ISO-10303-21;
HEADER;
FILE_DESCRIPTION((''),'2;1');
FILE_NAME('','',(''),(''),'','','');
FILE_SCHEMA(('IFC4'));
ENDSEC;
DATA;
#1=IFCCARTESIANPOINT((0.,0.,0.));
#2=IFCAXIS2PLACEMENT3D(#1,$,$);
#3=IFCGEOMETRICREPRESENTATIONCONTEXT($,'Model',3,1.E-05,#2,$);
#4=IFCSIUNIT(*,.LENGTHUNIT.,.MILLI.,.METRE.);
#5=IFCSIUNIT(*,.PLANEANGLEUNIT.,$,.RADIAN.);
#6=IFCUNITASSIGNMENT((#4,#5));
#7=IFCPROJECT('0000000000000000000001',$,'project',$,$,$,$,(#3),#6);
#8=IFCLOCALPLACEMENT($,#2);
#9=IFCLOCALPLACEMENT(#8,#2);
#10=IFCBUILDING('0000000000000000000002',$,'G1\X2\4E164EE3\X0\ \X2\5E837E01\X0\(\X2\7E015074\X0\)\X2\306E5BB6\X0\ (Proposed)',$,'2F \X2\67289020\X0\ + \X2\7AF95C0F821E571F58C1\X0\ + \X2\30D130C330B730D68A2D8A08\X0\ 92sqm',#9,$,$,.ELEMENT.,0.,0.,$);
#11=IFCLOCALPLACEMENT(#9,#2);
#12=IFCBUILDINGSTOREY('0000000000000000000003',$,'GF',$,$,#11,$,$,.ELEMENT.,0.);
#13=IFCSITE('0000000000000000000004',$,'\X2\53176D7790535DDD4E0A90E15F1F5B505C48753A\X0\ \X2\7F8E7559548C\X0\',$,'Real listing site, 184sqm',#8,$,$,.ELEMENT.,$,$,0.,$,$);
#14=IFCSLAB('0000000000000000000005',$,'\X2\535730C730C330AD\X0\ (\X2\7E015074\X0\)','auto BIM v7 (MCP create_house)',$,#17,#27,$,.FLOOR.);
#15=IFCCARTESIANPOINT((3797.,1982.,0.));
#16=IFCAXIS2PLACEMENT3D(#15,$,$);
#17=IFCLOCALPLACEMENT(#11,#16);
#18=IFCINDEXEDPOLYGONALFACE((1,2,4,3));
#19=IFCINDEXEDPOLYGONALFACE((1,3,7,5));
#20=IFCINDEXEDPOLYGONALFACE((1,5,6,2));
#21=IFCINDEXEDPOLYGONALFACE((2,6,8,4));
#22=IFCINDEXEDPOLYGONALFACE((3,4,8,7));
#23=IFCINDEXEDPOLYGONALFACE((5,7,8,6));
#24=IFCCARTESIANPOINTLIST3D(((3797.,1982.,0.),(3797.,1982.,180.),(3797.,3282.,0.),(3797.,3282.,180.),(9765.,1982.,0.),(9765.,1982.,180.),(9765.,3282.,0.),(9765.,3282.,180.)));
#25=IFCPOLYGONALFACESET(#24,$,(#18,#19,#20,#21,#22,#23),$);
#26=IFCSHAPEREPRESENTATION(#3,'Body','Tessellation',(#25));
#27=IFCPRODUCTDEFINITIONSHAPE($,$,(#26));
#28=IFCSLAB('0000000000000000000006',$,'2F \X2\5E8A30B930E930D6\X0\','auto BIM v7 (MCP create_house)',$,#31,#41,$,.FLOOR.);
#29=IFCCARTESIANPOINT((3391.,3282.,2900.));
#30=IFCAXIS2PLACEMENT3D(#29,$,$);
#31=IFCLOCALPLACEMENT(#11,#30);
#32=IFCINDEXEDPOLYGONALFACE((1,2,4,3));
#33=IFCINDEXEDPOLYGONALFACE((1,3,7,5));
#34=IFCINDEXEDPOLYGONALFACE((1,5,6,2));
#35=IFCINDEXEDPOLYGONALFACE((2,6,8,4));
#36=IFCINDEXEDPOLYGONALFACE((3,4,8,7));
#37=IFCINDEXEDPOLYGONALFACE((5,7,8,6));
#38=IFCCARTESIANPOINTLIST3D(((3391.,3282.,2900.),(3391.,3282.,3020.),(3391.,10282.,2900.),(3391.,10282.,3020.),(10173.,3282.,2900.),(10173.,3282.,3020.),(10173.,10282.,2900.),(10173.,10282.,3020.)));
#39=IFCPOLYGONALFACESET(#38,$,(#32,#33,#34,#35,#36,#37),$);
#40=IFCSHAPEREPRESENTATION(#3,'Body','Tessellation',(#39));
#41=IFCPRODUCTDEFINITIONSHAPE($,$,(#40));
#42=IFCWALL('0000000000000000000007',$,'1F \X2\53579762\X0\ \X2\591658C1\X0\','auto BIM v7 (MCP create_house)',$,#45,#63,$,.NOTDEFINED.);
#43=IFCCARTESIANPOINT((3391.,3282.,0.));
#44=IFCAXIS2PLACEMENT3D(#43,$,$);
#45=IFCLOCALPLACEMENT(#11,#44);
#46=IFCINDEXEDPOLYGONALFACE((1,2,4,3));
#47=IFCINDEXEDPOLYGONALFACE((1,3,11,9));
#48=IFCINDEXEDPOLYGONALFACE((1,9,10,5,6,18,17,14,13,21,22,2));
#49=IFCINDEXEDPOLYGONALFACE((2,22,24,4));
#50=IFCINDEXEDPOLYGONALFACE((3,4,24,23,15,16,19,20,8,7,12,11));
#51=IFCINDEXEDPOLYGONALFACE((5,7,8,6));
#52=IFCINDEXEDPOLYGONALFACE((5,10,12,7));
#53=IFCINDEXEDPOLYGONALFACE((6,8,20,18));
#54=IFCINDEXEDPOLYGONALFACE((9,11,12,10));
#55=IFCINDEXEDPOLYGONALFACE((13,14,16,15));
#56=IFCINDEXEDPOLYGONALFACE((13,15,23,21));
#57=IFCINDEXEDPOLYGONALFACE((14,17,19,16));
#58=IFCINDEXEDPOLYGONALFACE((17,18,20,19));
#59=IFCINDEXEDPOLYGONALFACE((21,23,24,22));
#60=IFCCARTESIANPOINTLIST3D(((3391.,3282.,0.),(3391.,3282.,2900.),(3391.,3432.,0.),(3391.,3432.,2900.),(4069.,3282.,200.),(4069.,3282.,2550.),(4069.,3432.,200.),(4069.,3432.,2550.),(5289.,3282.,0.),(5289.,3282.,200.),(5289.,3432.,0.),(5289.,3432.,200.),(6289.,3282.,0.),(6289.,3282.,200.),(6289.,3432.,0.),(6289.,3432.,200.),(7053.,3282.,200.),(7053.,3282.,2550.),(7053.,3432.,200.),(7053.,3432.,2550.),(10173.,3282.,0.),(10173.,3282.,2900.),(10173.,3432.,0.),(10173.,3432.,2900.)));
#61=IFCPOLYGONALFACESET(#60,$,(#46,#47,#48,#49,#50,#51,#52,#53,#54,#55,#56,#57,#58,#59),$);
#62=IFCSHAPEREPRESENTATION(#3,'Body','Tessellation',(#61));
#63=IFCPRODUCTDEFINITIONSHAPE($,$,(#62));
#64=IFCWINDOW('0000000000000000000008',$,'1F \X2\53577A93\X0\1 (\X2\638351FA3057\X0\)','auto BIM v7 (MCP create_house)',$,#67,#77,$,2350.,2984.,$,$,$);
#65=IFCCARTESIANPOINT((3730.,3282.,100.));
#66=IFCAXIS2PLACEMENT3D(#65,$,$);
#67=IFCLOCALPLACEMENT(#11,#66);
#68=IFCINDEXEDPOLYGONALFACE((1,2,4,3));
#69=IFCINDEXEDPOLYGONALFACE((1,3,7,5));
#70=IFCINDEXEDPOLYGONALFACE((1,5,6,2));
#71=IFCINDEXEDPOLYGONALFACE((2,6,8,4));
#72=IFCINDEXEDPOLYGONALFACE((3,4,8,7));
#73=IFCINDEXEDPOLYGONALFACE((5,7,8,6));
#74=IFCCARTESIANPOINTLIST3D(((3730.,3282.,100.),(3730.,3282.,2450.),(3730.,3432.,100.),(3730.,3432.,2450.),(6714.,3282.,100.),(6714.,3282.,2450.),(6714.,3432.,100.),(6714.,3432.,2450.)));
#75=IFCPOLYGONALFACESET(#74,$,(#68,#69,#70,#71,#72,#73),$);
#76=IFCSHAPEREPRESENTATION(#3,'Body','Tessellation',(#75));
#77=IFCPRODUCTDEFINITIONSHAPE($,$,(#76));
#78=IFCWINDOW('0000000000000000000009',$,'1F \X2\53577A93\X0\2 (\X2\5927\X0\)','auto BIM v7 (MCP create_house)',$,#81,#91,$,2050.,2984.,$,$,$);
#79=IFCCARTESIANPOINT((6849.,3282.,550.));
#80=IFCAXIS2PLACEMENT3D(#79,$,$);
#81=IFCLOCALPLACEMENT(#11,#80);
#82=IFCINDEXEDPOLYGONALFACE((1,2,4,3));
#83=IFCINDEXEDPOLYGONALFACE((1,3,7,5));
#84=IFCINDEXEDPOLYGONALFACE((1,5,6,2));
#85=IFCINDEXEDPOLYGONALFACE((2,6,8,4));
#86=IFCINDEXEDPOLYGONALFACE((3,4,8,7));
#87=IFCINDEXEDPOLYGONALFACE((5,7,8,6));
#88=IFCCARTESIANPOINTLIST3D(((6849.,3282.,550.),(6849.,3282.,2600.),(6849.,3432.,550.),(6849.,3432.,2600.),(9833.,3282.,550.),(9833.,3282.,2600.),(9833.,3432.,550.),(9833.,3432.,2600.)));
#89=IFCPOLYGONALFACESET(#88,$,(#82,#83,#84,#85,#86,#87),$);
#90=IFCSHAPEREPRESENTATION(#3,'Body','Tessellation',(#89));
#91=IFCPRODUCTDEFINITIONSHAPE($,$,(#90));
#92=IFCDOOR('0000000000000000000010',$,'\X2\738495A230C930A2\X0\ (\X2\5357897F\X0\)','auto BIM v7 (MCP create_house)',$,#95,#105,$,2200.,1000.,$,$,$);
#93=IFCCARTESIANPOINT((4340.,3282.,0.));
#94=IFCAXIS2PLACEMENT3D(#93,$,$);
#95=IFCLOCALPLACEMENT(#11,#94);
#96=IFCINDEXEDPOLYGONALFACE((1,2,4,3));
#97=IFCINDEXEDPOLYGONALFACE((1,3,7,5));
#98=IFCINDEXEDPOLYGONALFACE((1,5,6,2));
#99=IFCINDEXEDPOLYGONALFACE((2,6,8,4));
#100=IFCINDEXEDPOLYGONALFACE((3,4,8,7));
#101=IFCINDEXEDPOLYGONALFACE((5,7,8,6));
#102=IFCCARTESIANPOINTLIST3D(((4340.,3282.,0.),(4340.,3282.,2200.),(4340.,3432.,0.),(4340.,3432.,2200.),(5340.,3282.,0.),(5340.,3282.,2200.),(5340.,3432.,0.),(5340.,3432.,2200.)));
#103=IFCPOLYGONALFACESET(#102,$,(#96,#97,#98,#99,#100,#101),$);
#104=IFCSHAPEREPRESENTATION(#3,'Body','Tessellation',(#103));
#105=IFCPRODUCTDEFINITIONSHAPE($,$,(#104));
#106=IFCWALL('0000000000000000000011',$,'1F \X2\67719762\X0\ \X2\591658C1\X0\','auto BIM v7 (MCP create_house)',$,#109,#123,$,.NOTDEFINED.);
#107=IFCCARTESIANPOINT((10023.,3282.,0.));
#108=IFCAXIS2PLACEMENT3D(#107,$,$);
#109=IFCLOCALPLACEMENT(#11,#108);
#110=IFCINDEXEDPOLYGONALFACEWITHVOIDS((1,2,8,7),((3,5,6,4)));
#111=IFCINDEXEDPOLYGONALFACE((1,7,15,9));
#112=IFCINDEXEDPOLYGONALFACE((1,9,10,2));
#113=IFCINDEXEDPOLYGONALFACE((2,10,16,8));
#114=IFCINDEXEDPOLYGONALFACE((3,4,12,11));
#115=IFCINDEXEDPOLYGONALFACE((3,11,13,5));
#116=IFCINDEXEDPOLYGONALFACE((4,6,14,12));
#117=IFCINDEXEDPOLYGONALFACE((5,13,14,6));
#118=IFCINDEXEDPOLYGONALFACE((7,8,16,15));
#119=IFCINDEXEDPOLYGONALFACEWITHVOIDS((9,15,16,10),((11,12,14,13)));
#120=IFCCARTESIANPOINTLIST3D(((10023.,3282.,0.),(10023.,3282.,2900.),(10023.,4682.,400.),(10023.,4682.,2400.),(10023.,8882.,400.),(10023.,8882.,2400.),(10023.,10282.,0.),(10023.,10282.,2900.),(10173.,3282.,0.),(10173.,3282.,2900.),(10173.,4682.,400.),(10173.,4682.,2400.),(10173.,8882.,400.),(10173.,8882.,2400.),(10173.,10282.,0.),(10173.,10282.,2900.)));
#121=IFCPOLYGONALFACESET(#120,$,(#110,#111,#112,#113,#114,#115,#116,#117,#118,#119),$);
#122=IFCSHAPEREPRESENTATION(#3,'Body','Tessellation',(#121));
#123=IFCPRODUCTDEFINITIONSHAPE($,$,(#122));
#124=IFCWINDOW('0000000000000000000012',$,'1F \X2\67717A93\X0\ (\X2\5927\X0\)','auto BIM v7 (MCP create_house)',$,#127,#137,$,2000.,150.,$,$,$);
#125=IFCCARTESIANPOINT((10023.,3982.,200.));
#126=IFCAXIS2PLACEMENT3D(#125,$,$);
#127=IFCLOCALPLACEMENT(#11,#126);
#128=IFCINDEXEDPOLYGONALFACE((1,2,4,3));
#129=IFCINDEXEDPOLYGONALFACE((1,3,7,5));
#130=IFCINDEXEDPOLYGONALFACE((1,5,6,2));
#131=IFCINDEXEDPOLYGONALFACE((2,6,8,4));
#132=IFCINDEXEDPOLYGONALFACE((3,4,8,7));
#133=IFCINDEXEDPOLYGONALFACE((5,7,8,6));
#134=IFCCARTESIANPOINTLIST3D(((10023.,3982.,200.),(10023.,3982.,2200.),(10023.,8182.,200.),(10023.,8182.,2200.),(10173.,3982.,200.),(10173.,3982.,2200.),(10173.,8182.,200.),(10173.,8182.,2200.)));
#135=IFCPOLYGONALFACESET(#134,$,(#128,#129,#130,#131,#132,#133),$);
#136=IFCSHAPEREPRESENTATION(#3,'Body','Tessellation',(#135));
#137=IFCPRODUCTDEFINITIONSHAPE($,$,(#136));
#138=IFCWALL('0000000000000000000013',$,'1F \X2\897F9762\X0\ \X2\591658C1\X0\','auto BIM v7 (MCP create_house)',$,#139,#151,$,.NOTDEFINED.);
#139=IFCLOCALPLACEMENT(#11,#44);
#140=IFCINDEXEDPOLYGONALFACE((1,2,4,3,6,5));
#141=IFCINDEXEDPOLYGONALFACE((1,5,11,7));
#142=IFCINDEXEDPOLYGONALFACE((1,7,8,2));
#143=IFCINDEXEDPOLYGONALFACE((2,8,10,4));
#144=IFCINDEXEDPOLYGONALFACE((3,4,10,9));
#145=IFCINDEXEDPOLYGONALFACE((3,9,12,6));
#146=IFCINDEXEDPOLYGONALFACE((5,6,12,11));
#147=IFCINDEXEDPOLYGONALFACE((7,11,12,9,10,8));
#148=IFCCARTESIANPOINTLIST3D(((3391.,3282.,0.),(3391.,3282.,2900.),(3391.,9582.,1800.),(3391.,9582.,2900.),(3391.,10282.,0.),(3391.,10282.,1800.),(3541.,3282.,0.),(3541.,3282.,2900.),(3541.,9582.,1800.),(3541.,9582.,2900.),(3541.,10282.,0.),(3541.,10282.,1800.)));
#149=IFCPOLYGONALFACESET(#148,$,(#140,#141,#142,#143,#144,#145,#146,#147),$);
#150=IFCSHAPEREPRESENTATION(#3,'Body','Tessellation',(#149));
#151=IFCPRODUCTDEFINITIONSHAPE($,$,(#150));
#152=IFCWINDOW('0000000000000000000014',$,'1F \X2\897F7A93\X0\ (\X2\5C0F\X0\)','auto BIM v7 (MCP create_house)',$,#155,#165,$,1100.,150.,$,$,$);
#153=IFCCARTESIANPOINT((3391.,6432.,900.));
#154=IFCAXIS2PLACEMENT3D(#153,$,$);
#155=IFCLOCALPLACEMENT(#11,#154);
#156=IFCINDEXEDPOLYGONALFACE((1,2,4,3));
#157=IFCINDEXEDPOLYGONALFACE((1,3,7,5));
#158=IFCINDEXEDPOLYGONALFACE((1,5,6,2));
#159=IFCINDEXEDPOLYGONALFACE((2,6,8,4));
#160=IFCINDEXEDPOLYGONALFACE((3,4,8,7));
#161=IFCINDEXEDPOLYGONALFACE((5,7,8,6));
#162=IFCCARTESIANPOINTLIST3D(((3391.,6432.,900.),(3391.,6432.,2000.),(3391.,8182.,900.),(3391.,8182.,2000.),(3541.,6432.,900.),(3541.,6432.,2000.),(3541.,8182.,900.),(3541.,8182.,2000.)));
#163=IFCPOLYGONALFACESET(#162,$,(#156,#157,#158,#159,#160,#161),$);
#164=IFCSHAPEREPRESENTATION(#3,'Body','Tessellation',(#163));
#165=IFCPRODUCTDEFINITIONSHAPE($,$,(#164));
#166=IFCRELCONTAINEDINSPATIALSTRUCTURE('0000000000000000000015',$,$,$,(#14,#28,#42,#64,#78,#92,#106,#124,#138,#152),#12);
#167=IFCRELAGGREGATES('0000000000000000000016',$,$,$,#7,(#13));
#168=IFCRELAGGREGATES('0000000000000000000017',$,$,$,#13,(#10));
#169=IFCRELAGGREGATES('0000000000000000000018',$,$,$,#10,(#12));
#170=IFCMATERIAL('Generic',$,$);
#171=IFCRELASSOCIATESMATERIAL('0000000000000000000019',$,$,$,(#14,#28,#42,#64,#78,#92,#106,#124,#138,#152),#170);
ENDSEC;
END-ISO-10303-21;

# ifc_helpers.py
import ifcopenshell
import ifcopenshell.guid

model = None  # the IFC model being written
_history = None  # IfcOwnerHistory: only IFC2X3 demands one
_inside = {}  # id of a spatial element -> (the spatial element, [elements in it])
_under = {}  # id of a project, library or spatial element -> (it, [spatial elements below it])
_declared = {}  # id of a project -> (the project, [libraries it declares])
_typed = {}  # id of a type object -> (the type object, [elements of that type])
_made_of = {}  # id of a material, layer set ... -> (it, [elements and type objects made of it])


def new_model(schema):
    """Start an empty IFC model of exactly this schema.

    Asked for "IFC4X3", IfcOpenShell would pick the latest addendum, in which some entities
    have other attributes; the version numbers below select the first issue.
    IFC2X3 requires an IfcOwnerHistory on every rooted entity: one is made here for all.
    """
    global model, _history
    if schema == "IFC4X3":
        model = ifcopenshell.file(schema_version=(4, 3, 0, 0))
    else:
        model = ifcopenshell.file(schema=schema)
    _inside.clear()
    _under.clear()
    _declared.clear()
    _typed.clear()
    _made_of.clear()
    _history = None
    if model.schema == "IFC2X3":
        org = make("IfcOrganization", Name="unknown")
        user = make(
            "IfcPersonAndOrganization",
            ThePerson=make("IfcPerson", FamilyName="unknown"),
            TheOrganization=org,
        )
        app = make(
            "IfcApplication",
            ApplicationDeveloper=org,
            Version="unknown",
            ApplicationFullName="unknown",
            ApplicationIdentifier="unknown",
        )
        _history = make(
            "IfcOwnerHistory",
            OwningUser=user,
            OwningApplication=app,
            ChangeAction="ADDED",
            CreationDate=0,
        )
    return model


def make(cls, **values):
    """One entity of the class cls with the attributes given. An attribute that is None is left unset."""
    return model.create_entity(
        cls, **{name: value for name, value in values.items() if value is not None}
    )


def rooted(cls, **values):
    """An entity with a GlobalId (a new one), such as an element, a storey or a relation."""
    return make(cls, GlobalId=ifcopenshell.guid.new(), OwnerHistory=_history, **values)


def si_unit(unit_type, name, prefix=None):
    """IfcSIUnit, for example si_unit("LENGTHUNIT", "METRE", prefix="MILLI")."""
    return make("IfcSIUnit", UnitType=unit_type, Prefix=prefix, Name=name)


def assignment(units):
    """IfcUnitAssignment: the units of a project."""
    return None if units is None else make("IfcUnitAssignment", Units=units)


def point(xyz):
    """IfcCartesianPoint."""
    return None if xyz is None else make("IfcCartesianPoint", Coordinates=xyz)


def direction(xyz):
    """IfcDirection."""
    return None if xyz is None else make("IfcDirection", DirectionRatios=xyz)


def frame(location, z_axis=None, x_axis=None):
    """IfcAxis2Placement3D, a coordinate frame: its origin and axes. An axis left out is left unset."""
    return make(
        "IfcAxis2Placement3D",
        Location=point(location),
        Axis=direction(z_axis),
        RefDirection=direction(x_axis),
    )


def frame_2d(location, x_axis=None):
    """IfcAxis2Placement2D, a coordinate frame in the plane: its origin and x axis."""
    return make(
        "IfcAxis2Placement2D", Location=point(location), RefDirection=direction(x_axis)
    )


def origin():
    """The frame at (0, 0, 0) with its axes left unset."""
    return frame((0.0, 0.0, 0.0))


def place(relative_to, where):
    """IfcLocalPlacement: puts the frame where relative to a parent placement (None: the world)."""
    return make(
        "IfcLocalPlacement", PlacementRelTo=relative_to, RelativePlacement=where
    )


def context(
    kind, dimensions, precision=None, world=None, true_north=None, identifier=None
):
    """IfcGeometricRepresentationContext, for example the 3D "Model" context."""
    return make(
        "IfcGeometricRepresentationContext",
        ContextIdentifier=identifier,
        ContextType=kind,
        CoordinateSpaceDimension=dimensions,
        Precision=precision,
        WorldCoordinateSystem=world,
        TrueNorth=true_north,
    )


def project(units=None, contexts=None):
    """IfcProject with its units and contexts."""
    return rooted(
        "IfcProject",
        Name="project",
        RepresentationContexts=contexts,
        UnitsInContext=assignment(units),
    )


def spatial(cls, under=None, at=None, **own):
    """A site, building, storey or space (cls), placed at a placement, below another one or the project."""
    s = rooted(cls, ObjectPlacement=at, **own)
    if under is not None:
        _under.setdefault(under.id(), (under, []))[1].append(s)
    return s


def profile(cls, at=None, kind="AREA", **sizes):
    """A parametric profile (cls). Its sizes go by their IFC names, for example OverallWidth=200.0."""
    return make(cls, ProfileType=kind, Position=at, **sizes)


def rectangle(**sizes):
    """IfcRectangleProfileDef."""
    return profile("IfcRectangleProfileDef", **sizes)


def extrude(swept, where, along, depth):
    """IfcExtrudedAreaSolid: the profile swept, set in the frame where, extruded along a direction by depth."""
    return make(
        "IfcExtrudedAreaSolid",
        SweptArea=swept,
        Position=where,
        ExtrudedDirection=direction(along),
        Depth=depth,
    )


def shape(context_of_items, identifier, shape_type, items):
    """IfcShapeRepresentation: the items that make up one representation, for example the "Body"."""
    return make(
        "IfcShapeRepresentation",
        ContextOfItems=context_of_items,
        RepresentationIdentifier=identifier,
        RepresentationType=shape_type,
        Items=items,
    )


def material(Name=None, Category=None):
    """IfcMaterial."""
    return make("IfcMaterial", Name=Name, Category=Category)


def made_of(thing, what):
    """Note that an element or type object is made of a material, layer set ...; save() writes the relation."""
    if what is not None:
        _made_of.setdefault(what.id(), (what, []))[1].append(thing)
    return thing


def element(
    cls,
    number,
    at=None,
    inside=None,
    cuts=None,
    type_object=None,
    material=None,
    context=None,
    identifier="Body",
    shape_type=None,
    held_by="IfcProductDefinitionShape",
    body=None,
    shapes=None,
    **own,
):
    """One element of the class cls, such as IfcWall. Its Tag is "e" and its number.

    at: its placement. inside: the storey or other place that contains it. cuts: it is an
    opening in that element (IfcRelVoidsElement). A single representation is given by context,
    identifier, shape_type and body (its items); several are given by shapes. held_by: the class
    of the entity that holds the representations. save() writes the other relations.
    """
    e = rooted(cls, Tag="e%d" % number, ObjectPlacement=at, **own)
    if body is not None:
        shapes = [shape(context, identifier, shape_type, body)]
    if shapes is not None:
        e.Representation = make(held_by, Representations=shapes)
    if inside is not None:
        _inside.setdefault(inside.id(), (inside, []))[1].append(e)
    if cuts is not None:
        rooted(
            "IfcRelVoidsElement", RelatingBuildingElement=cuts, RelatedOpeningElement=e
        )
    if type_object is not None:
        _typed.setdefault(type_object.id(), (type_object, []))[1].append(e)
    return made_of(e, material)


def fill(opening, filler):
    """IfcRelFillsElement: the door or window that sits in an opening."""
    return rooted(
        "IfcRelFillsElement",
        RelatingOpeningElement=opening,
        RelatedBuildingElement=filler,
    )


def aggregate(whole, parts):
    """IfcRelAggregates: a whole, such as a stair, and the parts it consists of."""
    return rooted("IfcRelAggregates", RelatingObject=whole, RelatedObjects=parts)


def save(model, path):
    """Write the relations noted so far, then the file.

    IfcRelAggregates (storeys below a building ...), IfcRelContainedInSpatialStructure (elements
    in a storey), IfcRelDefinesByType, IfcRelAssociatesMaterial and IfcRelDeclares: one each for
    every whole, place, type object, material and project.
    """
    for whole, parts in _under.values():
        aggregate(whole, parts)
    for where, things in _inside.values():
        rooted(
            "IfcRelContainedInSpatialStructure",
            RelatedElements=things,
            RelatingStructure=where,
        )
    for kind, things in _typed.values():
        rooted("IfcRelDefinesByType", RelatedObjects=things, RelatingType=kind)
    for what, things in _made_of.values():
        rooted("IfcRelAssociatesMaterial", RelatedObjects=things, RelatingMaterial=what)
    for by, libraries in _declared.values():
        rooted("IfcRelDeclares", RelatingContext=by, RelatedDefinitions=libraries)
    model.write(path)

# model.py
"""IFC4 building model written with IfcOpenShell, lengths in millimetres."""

from ifc_helpers import new_model, si_unit, frame, frame_2d, origin, place, context, project, spatial, rectangle, extrude, material, element, fill, save


model = new_model("IFC4")

# Units and contexts
model_context = context("Model", 3, precision=1e-05, world=origin())
ifc_project = project(units=[si_unit("LENGTHUNIT", "METRE", prefix="MILLI"), si_unit("PLANEANGLEUNIT", "RADIAN")], contexts=[model_context])

# Site, building, storey
site_placement = place(None, origin())
site = spatial("IfcSite", under=ifc_project, at=site_placement, Name="北海道川上郡弟子屈町 美留和", ObjectType="Real listing site, 184sqm", CompositionType="ELEMENT", RefElevation=0.0)
building_placement = place(site_placement, origin())
building = spatial("IfcBuilding", under=site, at=building_placement, Name="G1世代 広縁(縁側)の家 (Proposed)", ObjectType="2F 木造 + 竹小舞土壁 + パッシブ設計 92sqm", CompositionType="ELEMENT", ElevationOfRefHeight=0.0, ElevationOfTerrain=0.0)
storey_placement = place(building_placement, origin())
storey = spatial("IfcBuildingStorey", under=building, at=storey_placement, Name="GF", CompositionType="ELEMENT", Elevation=0.0)

# Slabs
ifc_material = material(Name="Generic")
slab_1_placement = place(storey_placement, frame((3797.0, 1982.0, 0.0)))
element("IfcSlab", 1, at=slab_1_placement, inside=storey, material=ifc_material, Name="南デッキ (縁側)", Description="auto BIM v7 (MCP create_house)", PredefinedType="FLOOR", context=model_context, shape_type="SweptSolid", body=[
    extrude(rectangle(XDim=5968.0, YDim=1300.0, at=frame_2d((2984.0, 650.0))), frame((3797.0, 1982.0, 0.0)), (0.0, 0.0, 1.0), 180.0),
])
slab_2_placement = place(storey_placement, frame((3391.0, 3282.0, 2900.0)))
element("IfcSlab", 2, at=slab_2_placement, inside=storey, material=ifc_material, Name="2F 床スラブ", Description="auto BIM v7 (MCP create_house)", PredefinedType="FLOOR", context=model_context, shape_type="SweptSolid", body=[
    extrude(rectangle(XDim=6782.0, YDim=7000.0, at=frame_2d((3391.0, 3500.0))), frame((3391.0, 3282.0, 2900.0)), (0.0, 0.0, 1.0), 120.0),
])

# Wall, openings, windows, door
wall_1_placement = place(storey_placement, frame((3391.0, 3282.0, 0.0)))
wall_1 = element("IfcWall", 3, at=wall_1_placement, inside=storey, material=ifc_material, Name="1F 南面 外壁", Description="auto BIM v7 (MCP create_house)", PredefinedType="NOTDEFINED", context=model_context, shape_type="SweptSolid", body=[
    extrude(rectangle(XDim=6782.0, YDim=150.0, at=frame_2d((3391.0, 75.0))), frame((3391.0, 3282.0, 0.0)), (0.0, 0.0, 1.0), 2900.0),
])
opening_1_placement = place(storey_placement, frame((3730.0, 3282.0, 100.0)))
opening_1 = element("IfcOpeningElement", 4, at=opening_1_placement, cuts=wall_1, PredefinedType="NOTDEFINED", context=model_context, shape_type="SweptSolid", body=[
    extrude(rectangle(XDim=2984.0, YDim=150.0, at=frame_2d((1492.0, 75.0))), frame((3730.0, 3282.0, 100.0)), (0.0, 0.0, 1.0), 2350.0),
])
opening_2_placement = place(storey_placement, frame((6849.0, 3282.0, 550.0)))
opening_2 = element("IfcOpeningElement", 5, at=opening_2_placement, cuts=wall_1, PredefinedType="NOTDEFINED", context=model_context, shape_type="SweptSolid", body=[
    extrude(rectangle(XDim=2984.0, YDim=150.0, at=frame_2d((1492.0, 75.0))), frame((6849.0, 3282.0, 550.0)), (0.0, 0.0, 1.0), 2050.0),
])
opening_3_placement = place(storey_placement, frame((4340.0, 3282.0, 0.0)))
opening_3 = element("IfcOpeningElement", 6, at=opening_3_placement, cuts=wall_1, PredefinedType="NOTDEFINED", context=model_context, shape_type="SweptSolid", body=[
    extrude(rectangle(XDim=1000.0, YDim=150.0, at=frame_2d((500.0, 75.0))), frame((4340.0, 3282.0, 0.0)), (0.0, 0.0, 1.0), 2200.0),
])
window_1_placement = place(storey_placement, frame((3730.0, 3282.0, 100.0)))
window_1 = element("IfcWindow", 7, at=window_1_placement, inside=storey, material=ifc_material, Name="1F 南窓1 (掃出し)", Description="auto BIM v7 (MCP create_house)", OverallHeight=2350.0, OverallWidth=2984.0, context=model_context, shape_type="SweptSolid", body=[
    extrude(rectangle(XDim=2984.0, YDim=150.0, at=frame_2d((1492.0, 75.0))), frame((3730.0, 3282.0, 100.0)), (0.0, 0.0, 1.0), 2350.0),
])
fill(opening_1, window_1)
window_2_placement = place(storey_placement, frame((6849.0, 3282.0, 550.0)))
window_2 = element("IfcWindow", 8, at=window_2_placement, inside=storey, material=ifc_material, Name="1F 南窓2 (大)", Description="auto BIM v7 (MCP create_house)", OverallHeight=2050.0, OverallWidth=2984.0, context=model_context, shape_type="SweptSolid", body=[
    extrude(rectangle(XDim=2984.0, YDim=150.0, at=frame_2d((1492.0, 75.0))), frame((6849.0, 3282.0, 550.0)), (0.0, 0.0, 1.0), 2050.0),
])
fill(opening_2, window_2)
door_placement = place(storey_placement, frame((4340.0, 3282.0, 0.0)))
door = element("IfcDoor", 9, at=door_placement, inside=storey, material=ifc_material, Name="玄関ドア (南西)", Description="auto BIM v7 (MCP create_house)", OverallHeight=2200.0, OverallWidth=1000.0, context=model_context, shape_type="SweptSolid", body=[
    extrude(rectangle(XDim=1000.0, YDim=150.0, at=frame_2d((500.0, 75.0))), frame((4340.0, 3282.0, 0.0)), (0.0, 0.0, 1.0), 2200.0),
])
fill(opening_3, door)

# Walls, openings, windows
wall_2_placement = place(storey_placement, frame((10023.0, 3282.0, 0.0)))
wall_2 = element("IfcWall", 10, at=wall_2_placement, inside=storey, material=ifc_material, Name="1F 東面 外壁", Description="auto BIM v7 (MCP create_house)", PredefinedType="NOTDEFINED", context=model_context, shape_type="SweptSolid", body=[
    extrude(rectangle(XDim=150.0, YDim=7000.0, at=frame_2d((75.0, 3500.0))), frame((10023.0, 3282.0, 0.0)), (0.0, 0.0, 1.0), 2900.0),
])
opening_4_placement = place(storey_placement, frame((10023.0, 3982.0, 200.0)))
opening_4 = element("IfcOpeningElement", 11, at=opening_4_placement, cuts=wall_2, PredefinedType="NOTDEFINED", context=model_context, shape_type="SweptSolid", body=[
    extrude(rectangle(XDim=150.0, YDim=4200.0, at=frame_2d((75.0, 2100.0))), frame((10023.0, 3982.0, 200.0)), (0.0, 0.0, 1.0), 2000.0),
])
window_3_placement = place(storey_placement, frame((10023.0, 3982.0, 200.0)))
window_3 = element("IfcWindow", 12, at=window_3_placement, inside=storey, material=ifc_material, Name="1F 東窓 (大)", Description="auto BIM v7 (MCP create_house)", OverallHeight=2000.0, OverallWidth=150.0, context=model_context, shape_type="SweptSolid", body=[
    extrude(rectangle(XDim=150.0, YDim=4200.0, at=frame_2d((75.0, 2100.0))), frame((10023.0, 3982.0, 200.0)), (0.0, 0.0, 1.0), 2000.0),
])
fill(opening_4, window_3)
wall_3_placement = place(storey_placement, frame((3391.0, 3282.0, 0.0)))
wall_3 = element("IfcWall", 13, at=wall_3_placement, inside=storey, material=ifc_material, Name="1F 西面 外壁", Description="auto BIM v7 (MCP create_house)", PredefinedType="NOTDEFINED", context=model_context, shape_type="SweptSolid", body=[
    extrude(rectangle(XDim=150.0, YDim=7000.0, at=frame_2d((75.0, 3500.0))), frame((3391.0, 3282.0, 0.0)), (0.0, 0.0, 1.0), 2900.0),
])
opening_5_placement = place(storey_placement, frame((3391.0, 6432.0, 900.0)))
opening_5 = element("IfcOpeningElement", 14, at=opening_5_placement, cuts=wall_3, PredefinedType="NOTDEFINED", context=model_context, shape_type="SweptSolid", body=[
    extrude(rectangle(XDim=150.0, YDim=1750.0, at=frame_2d((75.0, 875.0))), frame((3391.0, 6432.0, 900.0)), (0.0, 0.0, 1.0), 1100.0),
])
window_4_placement = place(storey_placement, frame((3391.0, 6432.0, 900.0)))
window_4 = element("IfcWindow", 15, at=window_4_placement, inside=storey, material=ifc_material, Name="1F 西窓 (小)", Description="auto BIM v7 (MCP create_house)", OverallHeight=1100.0, OverallWidth=150.0, context=model_context, shape_type="SweptSolid", body=[
    extrude(rectangle(XDim=150.0, YDim=1750.0, at=frame_2d((75.0, 875.0))), frame((3391.0, 6432.0, 900.0)), (0.0, 0.0, 1.0), 1100.0),
])
fill(opening_5, window_4)

save(model, "model.ifc")
